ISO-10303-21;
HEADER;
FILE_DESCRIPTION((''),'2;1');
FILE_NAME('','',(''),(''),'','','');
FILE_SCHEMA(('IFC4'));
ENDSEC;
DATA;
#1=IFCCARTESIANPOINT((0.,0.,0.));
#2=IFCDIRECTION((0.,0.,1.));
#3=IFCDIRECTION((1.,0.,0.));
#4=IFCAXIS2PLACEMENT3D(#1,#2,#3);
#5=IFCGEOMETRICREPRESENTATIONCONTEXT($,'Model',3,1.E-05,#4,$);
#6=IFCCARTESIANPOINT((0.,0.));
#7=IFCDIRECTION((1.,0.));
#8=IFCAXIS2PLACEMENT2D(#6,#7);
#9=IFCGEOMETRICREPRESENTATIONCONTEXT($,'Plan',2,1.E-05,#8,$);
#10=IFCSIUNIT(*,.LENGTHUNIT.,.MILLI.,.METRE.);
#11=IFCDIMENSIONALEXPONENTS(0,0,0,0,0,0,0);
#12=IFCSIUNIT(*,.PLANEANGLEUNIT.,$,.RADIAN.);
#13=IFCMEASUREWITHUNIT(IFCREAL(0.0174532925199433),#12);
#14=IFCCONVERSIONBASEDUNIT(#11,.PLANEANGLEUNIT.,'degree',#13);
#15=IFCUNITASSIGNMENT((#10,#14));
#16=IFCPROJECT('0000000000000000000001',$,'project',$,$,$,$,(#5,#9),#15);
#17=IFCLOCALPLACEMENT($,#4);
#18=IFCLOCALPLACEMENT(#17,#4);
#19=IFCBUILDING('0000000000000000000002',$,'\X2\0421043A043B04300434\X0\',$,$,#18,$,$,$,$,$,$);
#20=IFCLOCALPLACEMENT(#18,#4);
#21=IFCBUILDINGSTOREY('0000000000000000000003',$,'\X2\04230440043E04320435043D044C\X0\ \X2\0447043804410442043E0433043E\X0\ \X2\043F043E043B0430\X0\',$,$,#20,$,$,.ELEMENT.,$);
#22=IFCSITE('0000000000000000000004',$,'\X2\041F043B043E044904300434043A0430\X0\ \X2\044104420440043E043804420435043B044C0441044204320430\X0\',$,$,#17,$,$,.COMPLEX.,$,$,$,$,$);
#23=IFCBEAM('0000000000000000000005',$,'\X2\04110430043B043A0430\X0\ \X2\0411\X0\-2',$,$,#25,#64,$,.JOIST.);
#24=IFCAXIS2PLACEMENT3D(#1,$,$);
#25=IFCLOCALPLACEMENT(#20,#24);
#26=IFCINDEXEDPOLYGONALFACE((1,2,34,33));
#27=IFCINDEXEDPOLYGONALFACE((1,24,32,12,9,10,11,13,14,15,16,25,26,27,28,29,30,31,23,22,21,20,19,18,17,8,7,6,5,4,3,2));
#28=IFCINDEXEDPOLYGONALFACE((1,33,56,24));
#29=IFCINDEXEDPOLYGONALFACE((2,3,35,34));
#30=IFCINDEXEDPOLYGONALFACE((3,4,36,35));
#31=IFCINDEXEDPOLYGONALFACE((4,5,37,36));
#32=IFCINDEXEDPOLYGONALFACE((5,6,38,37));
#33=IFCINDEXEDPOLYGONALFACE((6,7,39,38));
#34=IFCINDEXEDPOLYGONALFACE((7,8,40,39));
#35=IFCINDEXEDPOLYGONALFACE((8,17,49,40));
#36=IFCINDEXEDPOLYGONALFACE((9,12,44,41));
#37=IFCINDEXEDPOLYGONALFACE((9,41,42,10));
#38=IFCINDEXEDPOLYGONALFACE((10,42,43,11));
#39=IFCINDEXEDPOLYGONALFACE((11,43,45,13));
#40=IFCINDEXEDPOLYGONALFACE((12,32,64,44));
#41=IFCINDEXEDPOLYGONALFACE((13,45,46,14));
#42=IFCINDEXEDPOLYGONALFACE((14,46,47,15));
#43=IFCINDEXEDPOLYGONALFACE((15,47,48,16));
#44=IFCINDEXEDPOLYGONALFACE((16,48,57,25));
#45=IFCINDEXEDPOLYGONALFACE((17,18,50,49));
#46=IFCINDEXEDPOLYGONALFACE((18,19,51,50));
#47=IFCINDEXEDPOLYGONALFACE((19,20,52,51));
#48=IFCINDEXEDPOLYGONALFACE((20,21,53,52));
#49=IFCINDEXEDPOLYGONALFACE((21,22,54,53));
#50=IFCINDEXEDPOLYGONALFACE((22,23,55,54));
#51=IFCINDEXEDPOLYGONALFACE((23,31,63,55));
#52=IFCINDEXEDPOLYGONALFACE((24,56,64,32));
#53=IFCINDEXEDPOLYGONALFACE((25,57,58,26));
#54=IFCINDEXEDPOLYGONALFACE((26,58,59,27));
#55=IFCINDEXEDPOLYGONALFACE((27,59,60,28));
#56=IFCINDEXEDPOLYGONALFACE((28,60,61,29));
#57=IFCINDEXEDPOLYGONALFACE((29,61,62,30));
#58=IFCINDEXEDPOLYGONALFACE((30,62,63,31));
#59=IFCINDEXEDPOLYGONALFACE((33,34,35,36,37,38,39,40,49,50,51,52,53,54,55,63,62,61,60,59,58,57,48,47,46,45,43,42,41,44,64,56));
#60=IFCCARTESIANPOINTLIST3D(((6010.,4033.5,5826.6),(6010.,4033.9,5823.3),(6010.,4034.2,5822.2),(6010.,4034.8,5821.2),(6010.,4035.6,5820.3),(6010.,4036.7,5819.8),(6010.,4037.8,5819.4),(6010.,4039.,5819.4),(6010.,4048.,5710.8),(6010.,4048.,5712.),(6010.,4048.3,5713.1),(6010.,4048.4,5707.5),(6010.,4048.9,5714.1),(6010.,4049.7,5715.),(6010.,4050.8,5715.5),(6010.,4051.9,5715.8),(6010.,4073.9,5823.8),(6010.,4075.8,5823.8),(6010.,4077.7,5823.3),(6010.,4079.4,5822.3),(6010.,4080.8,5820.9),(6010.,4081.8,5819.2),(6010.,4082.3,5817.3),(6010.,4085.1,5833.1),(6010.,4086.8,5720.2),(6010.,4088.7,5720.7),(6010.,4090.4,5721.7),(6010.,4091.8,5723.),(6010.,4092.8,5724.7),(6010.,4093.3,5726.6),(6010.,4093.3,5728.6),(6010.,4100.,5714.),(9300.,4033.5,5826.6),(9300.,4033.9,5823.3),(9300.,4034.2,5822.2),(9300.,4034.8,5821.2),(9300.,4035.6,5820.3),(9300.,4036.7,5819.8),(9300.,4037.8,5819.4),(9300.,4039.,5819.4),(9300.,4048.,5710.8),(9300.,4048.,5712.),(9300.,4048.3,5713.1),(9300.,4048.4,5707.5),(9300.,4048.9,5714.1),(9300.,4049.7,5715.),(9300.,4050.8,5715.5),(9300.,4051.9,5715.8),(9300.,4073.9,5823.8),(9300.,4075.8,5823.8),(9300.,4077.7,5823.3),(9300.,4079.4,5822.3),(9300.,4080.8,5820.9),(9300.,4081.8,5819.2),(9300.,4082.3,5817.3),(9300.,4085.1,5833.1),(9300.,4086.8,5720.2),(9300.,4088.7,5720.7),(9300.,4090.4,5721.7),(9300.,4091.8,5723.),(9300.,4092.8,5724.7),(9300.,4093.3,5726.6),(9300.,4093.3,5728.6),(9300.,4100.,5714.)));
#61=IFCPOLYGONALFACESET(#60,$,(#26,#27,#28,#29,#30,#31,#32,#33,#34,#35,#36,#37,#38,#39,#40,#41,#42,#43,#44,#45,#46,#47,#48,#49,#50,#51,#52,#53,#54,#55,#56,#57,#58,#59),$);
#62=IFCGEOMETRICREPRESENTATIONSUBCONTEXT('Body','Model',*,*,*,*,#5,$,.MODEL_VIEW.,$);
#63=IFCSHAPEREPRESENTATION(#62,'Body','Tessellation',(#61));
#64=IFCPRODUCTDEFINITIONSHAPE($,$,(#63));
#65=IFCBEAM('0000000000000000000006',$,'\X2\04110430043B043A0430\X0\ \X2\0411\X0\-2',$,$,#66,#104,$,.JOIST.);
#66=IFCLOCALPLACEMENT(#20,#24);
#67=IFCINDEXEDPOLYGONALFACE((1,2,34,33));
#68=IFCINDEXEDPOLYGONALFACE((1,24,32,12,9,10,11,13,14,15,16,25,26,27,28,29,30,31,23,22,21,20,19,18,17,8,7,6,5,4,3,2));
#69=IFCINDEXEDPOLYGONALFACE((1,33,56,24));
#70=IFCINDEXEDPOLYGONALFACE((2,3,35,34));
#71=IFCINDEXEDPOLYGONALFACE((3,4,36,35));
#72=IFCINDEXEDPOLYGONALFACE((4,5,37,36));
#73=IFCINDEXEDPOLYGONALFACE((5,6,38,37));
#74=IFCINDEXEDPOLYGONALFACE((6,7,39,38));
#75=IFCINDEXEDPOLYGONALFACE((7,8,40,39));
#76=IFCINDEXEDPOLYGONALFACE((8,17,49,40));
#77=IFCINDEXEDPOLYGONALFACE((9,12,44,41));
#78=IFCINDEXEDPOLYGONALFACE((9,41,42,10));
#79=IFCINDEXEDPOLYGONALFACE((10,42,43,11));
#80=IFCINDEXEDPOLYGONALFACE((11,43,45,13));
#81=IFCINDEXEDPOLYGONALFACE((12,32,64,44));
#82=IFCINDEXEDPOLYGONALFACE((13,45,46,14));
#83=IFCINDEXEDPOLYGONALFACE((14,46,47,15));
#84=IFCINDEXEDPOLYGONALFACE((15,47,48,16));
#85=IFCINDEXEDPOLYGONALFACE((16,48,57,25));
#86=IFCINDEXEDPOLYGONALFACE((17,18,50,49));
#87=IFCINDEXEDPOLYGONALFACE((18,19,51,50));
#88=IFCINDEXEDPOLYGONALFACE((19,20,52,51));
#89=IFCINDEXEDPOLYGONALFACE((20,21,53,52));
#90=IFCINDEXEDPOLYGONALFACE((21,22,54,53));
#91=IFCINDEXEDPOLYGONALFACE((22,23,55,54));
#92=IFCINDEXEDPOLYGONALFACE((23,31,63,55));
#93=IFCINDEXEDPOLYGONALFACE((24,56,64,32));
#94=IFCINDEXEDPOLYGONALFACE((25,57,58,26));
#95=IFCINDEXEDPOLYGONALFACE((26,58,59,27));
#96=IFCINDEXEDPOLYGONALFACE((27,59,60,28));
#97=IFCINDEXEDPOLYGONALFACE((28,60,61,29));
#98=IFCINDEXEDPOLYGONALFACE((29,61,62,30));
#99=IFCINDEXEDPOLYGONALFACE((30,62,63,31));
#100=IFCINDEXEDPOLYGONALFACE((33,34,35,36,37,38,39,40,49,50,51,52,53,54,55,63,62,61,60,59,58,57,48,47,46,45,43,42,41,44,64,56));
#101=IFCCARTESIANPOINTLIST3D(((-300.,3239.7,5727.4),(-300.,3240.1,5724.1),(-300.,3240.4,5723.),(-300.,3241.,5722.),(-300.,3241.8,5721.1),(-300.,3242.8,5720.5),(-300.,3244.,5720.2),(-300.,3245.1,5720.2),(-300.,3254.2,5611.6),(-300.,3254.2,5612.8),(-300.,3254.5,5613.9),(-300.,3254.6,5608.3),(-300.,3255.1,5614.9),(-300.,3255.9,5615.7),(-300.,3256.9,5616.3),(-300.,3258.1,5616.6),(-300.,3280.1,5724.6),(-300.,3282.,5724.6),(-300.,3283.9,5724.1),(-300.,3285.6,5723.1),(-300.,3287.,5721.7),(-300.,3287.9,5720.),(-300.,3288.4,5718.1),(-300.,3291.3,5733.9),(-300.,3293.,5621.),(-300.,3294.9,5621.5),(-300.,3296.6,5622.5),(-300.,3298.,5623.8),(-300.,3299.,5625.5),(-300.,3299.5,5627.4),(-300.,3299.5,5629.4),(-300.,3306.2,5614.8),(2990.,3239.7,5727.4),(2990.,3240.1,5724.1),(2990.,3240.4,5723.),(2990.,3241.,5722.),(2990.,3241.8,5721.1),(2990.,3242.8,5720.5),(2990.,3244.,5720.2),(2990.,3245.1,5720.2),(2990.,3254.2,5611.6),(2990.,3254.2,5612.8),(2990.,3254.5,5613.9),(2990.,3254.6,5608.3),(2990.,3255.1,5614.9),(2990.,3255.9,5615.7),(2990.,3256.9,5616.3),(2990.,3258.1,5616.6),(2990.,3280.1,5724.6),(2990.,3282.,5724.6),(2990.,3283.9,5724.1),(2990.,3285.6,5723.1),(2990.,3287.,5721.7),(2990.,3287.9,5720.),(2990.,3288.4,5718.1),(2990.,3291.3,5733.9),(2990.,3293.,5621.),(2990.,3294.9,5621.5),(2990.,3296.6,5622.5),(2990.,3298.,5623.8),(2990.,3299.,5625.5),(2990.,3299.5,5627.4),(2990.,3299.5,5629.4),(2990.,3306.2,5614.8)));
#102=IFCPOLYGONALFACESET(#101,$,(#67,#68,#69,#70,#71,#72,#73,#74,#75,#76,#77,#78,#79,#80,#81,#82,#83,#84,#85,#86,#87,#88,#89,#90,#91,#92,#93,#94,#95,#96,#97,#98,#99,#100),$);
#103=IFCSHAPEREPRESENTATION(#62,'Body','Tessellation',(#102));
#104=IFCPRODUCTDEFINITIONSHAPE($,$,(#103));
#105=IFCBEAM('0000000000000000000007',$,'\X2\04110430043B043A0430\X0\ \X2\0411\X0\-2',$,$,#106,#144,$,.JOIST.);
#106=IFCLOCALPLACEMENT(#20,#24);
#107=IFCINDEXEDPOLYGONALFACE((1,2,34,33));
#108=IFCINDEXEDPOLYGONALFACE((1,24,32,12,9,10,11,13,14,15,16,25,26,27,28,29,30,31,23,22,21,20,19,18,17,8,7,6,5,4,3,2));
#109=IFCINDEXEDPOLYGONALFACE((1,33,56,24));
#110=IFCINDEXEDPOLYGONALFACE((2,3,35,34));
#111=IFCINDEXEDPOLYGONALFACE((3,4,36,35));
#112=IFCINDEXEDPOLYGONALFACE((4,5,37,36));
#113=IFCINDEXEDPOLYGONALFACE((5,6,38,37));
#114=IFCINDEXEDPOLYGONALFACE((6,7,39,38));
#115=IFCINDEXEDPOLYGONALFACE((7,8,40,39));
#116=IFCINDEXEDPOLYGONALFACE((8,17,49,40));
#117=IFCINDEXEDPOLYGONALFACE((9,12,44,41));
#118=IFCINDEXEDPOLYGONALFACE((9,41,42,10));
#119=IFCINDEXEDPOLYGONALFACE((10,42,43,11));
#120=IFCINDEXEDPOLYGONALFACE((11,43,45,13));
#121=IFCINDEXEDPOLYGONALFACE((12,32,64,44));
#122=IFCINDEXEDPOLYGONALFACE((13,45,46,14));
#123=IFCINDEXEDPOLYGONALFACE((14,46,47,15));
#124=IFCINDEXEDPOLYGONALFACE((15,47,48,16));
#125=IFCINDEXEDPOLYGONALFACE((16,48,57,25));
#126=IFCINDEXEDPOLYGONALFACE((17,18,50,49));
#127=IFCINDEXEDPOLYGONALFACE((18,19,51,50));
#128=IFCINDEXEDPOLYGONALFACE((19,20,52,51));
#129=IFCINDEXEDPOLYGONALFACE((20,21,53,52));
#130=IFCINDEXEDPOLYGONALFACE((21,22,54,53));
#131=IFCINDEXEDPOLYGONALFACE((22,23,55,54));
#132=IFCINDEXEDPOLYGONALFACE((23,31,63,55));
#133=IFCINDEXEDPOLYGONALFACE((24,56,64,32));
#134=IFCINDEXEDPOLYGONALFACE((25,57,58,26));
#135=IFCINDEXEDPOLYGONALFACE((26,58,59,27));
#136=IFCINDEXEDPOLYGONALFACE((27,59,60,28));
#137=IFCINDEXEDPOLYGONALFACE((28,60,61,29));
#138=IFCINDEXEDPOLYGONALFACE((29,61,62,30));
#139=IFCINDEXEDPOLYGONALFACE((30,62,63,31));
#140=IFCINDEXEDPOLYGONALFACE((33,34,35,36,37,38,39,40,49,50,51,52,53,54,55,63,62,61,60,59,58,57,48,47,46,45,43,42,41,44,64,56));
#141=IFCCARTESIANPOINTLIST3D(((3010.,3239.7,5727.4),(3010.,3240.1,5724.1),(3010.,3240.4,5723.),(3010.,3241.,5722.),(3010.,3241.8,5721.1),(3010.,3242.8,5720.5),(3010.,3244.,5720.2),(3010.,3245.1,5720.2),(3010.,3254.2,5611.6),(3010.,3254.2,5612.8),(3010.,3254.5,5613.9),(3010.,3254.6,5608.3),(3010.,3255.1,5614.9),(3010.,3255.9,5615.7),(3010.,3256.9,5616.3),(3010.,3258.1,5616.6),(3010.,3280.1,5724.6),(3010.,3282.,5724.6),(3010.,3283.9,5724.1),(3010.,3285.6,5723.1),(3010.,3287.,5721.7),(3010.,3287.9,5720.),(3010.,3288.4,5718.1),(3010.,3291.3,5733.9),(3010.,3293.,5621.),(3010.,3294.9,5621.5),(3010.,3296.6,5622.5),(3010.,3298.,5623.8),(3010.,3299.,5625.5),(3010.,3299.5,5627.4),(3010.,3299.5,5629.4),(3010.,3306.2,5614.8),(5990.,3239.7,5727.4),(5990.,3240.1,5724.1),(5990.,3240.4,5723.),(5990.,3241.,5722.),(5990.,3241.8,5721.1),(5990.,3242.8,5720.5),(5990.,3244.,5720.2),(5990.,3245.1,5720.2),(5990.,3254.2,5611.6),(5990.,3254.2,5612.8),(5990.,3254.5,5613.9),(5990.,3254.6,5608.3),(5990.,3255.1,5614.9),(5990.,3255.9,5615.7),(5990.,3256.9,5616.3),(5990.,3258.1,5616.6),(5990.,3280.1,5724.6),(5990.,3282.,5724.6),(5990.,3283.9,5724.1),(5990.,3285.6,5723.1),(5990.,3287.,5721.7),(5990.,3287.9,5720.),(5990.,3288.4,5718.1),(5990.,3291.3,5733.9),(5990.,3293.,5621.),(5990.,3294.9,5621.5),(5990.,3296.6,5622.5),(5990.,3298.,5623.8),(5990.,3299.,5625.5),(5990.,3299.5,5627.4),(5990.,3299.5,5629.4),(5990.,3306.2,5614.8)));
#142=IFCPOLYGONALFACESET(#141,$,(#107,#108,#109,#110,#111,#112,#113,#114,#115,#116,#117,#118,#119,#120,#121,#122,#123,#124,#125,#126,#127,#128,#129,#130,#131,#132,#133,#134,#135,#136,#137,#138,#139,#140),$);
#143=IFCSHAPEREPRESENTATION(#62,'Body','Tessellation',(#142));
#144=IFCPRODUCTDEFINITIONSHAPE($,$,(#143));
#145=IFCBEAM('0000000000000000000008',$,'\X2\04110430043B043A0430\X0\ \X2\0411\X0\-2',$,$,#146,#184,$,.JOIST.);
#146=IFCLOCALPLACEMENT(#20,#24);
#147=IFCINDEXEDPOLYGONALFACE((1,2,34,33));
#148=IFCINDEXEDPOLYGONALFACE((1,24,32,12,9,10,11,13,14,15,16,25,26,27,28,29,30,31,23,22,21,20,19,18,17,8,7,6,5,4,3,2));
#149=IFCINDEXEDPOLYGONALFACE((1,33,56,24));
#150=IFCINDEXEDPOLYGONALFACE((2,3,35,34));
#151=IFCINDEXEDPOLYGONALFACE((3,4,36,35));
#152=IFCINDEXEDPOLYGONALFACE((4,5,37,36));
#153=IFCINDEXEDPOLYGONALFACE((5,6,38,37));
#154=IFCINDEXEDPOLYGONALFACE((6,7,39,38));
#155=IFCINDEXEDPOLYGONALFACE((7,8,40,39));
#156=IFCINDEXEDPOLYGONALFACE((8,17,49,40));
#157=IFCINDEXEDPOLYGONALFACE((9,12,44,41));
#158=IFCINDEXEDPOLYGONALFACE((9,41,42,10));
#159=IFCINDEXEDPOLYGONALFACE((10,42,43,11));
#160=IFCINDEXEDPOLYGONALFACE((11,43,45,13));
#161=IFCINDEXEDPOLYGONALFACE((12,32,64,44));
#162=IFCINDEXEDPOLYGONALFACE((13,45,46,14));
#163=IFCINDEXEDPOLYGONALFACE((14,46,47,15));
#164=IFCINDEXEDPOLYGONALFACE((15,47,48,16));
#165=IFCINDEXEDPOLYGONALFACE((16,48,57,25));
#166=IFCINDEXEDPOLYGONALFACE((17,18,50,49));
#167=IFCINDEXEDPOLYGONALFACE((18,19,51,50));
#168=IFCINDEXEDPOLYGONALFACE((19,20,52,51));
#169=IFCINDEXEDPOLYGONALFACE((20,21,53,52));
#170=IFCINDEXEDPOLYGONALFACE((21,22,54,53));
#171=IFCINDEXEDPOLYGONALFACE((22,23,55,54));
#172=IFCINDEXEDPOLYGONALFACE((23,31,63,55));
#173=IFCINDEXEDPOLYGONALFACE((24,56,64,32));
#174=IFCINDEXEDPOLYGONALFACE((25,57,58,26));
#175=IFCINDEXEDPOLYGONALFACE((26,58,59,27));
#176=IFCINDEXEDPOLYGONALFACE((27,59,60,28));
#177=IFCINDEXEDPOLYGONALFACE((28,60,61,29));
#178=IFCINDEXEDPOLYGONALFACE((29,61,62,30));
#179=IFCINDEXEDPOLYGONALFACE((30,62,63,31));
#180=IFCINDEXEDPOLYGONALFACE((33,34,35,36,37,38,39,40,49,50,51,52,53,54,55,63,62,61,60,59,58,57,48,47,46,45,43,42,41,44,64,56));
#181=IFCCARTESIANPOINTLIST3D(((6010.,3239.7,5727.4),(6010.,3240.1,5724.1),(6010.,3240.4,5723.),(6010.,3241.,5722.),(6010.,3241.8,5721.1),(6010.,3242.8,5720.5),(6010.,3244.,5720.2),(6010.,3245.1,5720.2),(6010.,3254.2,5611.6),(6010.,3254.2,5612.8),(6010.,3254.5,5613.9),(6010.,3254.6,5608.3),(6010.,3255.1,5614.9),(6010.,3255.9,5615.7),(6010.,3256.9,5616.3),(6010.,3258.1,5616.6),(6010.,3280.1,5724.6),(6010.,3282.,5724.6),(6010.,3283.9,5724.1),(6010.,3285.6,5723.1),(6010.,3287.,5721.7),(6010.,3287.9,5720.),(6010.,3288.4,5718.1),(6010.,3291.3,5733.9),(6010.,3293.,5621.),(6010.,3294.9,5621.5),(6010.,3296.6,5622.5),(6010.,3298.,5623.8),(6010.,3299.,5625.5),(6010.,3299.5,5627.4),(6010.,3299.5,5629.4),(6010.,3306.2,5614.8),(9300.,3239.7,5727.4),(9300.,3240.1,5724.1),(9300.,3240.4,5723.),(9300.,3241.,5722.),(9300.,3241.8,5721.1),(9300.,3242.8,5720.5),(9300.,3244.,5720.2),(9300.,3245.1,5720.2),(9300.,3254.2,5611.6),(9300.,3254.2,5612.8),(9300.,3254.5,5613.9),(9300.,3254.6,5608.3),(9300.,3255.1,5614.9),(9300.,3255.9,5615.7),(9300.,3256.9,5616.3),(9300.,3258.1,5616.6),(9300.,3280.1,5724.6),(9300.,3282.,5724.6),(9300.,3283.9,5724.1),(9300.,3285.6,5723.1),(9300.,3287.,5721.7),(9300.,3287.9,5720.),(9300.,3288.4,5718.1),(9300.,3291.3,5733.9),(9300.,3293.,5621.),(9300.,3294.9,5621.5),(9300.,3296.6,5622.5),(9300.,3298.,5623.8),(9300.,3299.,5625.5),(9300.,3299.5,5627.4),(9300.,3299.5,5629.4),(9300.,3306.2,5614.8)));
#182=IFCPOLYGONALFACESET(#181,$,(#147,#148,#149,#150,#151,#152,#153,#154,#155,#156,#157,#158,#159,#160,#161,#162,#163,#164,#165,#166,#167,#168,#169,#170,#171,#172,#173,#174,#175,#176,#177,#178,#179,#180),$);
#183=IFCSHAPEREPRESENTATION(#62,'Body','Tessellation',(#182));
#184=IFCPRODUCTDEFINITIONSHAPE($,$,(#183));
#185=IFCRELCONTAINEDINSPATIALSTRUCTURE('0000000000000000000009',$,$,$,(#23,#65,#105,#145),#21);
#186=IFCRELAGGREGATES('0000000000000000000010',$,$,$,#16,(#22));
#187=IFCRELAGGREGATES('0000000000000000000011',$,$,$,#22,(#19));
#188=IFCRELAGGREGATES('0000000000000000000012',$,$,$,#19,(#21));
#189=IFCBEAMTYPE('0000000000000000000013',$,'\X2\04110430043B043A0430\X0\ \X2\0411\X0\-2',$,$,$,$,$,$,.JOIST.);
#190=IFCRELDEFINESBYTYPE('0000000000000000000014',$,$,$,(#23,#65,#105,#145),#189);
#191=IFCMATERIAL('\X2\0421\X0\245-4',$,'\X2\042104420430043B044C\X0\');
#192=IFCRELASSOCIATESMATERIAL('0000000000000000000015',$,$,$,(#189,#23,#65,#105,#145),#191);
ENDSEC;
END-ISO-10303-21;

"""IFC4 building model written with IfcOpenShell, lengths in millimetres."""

from ifc_helpers import new_model, entity, si_unit, converted_unit, frame, origin_with_axes, origin_2d_with_axis, place, context, subcontext, project, spatial, u_section, extrude, material, material_profile, profile_set, profile_usage, type_object, element, save


model = new_model("IFC4")

# Units and contexts
model_context = context("Model", 3, precision=1e-05, world=origin_with_axes())
plan_context = context("Plan", 2, precision=1e-05, world=origin_2d_with_axis())
body_context = subcontext(model_context, "Body", "Model", "MODEL_VIEW")
ifc_project = project(units=[si_unit("LENGTHUNIT", "METRE", prefix="MILLI"), converted_unit("PLANEANGLEUNIT", "degree", entity("IfcReal", 0.0174532925199433), si_unit("PLANEANGLEUNIT", "RADIAN"), dimensions=[0, 0, 0, 0, 0, 0, 0])], contexts=[model_context, plan_context])

# Site, building, storey
site_placement = place(None, origin_with_axes())
site = spatial("IfcSite", under=ifc_project, at=site_placement, Name="Площадка строительства", CompositionType="COMPLEX")
building_placement = place(site_placement, origin_with_axes())
building = spatial("IfcBuilding", under=site, at=building_placement, Name="Склад")
storey_placement = place(building_placement, origin_with_axes())
storey = spatial("IfcBuildingStorey", under=building, at=storey_placement, Name="Уровень чистого пола", CompositionType="ELEMENT")

# Beams
ifc_material_1 = material(Name="С245-4", Category="Сталь")
ifc_material_profile_1 = material_profile(ifc_material_1, u_section(Depth=120.0, FlangeWidth=52.0, WebThickness=4.8, FlangeThickness=7.8, FilletRadius=7.5, EdgeRadius=4.5, FlangeSlope=0.0))
ifc_profile_set_1 = profile_set([ifc_material_profile_1], Name="U12P_S245-4")
beam_type_1 = type_object("IfcBeamType", Name="Балка Б-2", PredefinedType="JOIST", material=ifc_profile_set_1)
ifc_profile_usage_1 = profile_usage(ifc_profile_set_1, cardinal=3)
beam_1_placement = place(storey_placement, frame((9300.0, 4100.0, 5714.0), z_axis=(-1.0, 0.0, 0.0), x_axis=(0.0, -0.99228, -0.12402)))
element("IfcBeam", 1, at=beam_1_placement, inside=storey, type_object=beam_type_1, material=ifc_profile_usage_1, Name="Балка Б-2", PredefinedType="JOIST", context=body_context, shape_type="SweptSolid", body=[
    extrude(u_section(Depth=120.0, FlangeWidth=52.0, WebThickness=4.8, FlangeThickness=7.8, FilletRadius=7.5, EdgeRadius=4.5, FlangeSlope=0.0), frame((26.0, 60.0, 0.0), z_axis=(0.0, 0.0, 1.0), x_axis=(1.0, 0.0, 0.0)), (0.0, 0.0, 1.0), 3290.0),
])
ifc_profile_usage_2 = profile_usage(ifc_profile_set_1, cardinal=3)
beam_2_placement = place(storey_placement, frame((2990.0, 3306.2, 5614.8), z_axis=(-1.0, 0.0, 0.0), x_axis=(0.0, -0.99228, -0.124019)))
element("IfcBeam", 2, at=beam_2_placement, inside=storey, type_object=beam_type_1, material=ifc_profile_usage_2, Name="Балка Б-2", PredefinedType="JOIST", context=body_context, shape_type="SweptSolid", body=[
    extrude(u_section(Depth=120.0, FlangeWidth=52.0, WebThickness=4.8, FlangeThickness=7.8, FilletRadius=7.5, EdgeRadius=4.5, FlangeSlope=0.0), frame((26.0, 60.0, 0.0), z_axis=(0.0, 0.0, 1.0), x_axis=(1.0, 0.0, 0.0)), (0.0, 0.0, 1.0), 3290.0),
])
ifc_profile_usage_3 = profile_usage(ifc_profile_set_1, cardinal=3)
beam_3_placement = place(storey_placement, frame((5990.0, 3306.2, 5614.8), z_axis=(-1.0, 0.0, 0.0), x_axis=(0.0, -0.99228, -0.12402)))
element("IfcBeam", 3, at=beam_3_placement, inside=storey, type_object=beam_type_1, material=ifc_profile_usage_3, Name="Балка Б-2", PredefinedType="JOIST", context=body_context, shape_type="SweptSolid", body=[
    extrude(u_section(Depth=120.0, FlangeWidth=52.0, WebThickness=4.8, FlangeThickness=7.8, FilletRadius=7.5, EdgeRadius=4.5, FlangeSlope=0.0), frame((26.0, 60.0, 0.0), z_axis=(0.0, 0.0, 1.0), x_axis=(1.0, 0.0, 0.0)), (0.0, 0.0, 1.0), 2980.0),
])
ifc_profile_usage_4 = profile_usage(ifc_profile_set_1, cardinal=3)
beam_4_placement = place(storey_placement, frame((9300.0, 3306.2, 5614.8), z_axis=(-1.0, 0.0, 0.0), x_axis=(0.0, -0.99228, -0.12402)))
element("IfcBeam", 4, at=beam_4_placement, inside=storey, type_object=beam_type_1, material=ifc_profile_usage_4, Name="Балка Б-2", PredefinedType="JOIST", context=body_context, shape_type="SweptSolid", body=[
    extrude(u_section(Depth=120.0, FlangeWidth=52.0, WebThickness=4.8, FlangeThickness=7.8, FilletRadius=7.5, EdgeRadius=4.5, FlangeSlope=0.0), frame((26.0, 60.0, 0.0), z_axis=(0.0, 0.0, 1.0), x_axis=(1.0, 0.0, 0.0)), (0.0, 0.0, 1.0), 3290.0),
])

save(model, "model.ifc")
